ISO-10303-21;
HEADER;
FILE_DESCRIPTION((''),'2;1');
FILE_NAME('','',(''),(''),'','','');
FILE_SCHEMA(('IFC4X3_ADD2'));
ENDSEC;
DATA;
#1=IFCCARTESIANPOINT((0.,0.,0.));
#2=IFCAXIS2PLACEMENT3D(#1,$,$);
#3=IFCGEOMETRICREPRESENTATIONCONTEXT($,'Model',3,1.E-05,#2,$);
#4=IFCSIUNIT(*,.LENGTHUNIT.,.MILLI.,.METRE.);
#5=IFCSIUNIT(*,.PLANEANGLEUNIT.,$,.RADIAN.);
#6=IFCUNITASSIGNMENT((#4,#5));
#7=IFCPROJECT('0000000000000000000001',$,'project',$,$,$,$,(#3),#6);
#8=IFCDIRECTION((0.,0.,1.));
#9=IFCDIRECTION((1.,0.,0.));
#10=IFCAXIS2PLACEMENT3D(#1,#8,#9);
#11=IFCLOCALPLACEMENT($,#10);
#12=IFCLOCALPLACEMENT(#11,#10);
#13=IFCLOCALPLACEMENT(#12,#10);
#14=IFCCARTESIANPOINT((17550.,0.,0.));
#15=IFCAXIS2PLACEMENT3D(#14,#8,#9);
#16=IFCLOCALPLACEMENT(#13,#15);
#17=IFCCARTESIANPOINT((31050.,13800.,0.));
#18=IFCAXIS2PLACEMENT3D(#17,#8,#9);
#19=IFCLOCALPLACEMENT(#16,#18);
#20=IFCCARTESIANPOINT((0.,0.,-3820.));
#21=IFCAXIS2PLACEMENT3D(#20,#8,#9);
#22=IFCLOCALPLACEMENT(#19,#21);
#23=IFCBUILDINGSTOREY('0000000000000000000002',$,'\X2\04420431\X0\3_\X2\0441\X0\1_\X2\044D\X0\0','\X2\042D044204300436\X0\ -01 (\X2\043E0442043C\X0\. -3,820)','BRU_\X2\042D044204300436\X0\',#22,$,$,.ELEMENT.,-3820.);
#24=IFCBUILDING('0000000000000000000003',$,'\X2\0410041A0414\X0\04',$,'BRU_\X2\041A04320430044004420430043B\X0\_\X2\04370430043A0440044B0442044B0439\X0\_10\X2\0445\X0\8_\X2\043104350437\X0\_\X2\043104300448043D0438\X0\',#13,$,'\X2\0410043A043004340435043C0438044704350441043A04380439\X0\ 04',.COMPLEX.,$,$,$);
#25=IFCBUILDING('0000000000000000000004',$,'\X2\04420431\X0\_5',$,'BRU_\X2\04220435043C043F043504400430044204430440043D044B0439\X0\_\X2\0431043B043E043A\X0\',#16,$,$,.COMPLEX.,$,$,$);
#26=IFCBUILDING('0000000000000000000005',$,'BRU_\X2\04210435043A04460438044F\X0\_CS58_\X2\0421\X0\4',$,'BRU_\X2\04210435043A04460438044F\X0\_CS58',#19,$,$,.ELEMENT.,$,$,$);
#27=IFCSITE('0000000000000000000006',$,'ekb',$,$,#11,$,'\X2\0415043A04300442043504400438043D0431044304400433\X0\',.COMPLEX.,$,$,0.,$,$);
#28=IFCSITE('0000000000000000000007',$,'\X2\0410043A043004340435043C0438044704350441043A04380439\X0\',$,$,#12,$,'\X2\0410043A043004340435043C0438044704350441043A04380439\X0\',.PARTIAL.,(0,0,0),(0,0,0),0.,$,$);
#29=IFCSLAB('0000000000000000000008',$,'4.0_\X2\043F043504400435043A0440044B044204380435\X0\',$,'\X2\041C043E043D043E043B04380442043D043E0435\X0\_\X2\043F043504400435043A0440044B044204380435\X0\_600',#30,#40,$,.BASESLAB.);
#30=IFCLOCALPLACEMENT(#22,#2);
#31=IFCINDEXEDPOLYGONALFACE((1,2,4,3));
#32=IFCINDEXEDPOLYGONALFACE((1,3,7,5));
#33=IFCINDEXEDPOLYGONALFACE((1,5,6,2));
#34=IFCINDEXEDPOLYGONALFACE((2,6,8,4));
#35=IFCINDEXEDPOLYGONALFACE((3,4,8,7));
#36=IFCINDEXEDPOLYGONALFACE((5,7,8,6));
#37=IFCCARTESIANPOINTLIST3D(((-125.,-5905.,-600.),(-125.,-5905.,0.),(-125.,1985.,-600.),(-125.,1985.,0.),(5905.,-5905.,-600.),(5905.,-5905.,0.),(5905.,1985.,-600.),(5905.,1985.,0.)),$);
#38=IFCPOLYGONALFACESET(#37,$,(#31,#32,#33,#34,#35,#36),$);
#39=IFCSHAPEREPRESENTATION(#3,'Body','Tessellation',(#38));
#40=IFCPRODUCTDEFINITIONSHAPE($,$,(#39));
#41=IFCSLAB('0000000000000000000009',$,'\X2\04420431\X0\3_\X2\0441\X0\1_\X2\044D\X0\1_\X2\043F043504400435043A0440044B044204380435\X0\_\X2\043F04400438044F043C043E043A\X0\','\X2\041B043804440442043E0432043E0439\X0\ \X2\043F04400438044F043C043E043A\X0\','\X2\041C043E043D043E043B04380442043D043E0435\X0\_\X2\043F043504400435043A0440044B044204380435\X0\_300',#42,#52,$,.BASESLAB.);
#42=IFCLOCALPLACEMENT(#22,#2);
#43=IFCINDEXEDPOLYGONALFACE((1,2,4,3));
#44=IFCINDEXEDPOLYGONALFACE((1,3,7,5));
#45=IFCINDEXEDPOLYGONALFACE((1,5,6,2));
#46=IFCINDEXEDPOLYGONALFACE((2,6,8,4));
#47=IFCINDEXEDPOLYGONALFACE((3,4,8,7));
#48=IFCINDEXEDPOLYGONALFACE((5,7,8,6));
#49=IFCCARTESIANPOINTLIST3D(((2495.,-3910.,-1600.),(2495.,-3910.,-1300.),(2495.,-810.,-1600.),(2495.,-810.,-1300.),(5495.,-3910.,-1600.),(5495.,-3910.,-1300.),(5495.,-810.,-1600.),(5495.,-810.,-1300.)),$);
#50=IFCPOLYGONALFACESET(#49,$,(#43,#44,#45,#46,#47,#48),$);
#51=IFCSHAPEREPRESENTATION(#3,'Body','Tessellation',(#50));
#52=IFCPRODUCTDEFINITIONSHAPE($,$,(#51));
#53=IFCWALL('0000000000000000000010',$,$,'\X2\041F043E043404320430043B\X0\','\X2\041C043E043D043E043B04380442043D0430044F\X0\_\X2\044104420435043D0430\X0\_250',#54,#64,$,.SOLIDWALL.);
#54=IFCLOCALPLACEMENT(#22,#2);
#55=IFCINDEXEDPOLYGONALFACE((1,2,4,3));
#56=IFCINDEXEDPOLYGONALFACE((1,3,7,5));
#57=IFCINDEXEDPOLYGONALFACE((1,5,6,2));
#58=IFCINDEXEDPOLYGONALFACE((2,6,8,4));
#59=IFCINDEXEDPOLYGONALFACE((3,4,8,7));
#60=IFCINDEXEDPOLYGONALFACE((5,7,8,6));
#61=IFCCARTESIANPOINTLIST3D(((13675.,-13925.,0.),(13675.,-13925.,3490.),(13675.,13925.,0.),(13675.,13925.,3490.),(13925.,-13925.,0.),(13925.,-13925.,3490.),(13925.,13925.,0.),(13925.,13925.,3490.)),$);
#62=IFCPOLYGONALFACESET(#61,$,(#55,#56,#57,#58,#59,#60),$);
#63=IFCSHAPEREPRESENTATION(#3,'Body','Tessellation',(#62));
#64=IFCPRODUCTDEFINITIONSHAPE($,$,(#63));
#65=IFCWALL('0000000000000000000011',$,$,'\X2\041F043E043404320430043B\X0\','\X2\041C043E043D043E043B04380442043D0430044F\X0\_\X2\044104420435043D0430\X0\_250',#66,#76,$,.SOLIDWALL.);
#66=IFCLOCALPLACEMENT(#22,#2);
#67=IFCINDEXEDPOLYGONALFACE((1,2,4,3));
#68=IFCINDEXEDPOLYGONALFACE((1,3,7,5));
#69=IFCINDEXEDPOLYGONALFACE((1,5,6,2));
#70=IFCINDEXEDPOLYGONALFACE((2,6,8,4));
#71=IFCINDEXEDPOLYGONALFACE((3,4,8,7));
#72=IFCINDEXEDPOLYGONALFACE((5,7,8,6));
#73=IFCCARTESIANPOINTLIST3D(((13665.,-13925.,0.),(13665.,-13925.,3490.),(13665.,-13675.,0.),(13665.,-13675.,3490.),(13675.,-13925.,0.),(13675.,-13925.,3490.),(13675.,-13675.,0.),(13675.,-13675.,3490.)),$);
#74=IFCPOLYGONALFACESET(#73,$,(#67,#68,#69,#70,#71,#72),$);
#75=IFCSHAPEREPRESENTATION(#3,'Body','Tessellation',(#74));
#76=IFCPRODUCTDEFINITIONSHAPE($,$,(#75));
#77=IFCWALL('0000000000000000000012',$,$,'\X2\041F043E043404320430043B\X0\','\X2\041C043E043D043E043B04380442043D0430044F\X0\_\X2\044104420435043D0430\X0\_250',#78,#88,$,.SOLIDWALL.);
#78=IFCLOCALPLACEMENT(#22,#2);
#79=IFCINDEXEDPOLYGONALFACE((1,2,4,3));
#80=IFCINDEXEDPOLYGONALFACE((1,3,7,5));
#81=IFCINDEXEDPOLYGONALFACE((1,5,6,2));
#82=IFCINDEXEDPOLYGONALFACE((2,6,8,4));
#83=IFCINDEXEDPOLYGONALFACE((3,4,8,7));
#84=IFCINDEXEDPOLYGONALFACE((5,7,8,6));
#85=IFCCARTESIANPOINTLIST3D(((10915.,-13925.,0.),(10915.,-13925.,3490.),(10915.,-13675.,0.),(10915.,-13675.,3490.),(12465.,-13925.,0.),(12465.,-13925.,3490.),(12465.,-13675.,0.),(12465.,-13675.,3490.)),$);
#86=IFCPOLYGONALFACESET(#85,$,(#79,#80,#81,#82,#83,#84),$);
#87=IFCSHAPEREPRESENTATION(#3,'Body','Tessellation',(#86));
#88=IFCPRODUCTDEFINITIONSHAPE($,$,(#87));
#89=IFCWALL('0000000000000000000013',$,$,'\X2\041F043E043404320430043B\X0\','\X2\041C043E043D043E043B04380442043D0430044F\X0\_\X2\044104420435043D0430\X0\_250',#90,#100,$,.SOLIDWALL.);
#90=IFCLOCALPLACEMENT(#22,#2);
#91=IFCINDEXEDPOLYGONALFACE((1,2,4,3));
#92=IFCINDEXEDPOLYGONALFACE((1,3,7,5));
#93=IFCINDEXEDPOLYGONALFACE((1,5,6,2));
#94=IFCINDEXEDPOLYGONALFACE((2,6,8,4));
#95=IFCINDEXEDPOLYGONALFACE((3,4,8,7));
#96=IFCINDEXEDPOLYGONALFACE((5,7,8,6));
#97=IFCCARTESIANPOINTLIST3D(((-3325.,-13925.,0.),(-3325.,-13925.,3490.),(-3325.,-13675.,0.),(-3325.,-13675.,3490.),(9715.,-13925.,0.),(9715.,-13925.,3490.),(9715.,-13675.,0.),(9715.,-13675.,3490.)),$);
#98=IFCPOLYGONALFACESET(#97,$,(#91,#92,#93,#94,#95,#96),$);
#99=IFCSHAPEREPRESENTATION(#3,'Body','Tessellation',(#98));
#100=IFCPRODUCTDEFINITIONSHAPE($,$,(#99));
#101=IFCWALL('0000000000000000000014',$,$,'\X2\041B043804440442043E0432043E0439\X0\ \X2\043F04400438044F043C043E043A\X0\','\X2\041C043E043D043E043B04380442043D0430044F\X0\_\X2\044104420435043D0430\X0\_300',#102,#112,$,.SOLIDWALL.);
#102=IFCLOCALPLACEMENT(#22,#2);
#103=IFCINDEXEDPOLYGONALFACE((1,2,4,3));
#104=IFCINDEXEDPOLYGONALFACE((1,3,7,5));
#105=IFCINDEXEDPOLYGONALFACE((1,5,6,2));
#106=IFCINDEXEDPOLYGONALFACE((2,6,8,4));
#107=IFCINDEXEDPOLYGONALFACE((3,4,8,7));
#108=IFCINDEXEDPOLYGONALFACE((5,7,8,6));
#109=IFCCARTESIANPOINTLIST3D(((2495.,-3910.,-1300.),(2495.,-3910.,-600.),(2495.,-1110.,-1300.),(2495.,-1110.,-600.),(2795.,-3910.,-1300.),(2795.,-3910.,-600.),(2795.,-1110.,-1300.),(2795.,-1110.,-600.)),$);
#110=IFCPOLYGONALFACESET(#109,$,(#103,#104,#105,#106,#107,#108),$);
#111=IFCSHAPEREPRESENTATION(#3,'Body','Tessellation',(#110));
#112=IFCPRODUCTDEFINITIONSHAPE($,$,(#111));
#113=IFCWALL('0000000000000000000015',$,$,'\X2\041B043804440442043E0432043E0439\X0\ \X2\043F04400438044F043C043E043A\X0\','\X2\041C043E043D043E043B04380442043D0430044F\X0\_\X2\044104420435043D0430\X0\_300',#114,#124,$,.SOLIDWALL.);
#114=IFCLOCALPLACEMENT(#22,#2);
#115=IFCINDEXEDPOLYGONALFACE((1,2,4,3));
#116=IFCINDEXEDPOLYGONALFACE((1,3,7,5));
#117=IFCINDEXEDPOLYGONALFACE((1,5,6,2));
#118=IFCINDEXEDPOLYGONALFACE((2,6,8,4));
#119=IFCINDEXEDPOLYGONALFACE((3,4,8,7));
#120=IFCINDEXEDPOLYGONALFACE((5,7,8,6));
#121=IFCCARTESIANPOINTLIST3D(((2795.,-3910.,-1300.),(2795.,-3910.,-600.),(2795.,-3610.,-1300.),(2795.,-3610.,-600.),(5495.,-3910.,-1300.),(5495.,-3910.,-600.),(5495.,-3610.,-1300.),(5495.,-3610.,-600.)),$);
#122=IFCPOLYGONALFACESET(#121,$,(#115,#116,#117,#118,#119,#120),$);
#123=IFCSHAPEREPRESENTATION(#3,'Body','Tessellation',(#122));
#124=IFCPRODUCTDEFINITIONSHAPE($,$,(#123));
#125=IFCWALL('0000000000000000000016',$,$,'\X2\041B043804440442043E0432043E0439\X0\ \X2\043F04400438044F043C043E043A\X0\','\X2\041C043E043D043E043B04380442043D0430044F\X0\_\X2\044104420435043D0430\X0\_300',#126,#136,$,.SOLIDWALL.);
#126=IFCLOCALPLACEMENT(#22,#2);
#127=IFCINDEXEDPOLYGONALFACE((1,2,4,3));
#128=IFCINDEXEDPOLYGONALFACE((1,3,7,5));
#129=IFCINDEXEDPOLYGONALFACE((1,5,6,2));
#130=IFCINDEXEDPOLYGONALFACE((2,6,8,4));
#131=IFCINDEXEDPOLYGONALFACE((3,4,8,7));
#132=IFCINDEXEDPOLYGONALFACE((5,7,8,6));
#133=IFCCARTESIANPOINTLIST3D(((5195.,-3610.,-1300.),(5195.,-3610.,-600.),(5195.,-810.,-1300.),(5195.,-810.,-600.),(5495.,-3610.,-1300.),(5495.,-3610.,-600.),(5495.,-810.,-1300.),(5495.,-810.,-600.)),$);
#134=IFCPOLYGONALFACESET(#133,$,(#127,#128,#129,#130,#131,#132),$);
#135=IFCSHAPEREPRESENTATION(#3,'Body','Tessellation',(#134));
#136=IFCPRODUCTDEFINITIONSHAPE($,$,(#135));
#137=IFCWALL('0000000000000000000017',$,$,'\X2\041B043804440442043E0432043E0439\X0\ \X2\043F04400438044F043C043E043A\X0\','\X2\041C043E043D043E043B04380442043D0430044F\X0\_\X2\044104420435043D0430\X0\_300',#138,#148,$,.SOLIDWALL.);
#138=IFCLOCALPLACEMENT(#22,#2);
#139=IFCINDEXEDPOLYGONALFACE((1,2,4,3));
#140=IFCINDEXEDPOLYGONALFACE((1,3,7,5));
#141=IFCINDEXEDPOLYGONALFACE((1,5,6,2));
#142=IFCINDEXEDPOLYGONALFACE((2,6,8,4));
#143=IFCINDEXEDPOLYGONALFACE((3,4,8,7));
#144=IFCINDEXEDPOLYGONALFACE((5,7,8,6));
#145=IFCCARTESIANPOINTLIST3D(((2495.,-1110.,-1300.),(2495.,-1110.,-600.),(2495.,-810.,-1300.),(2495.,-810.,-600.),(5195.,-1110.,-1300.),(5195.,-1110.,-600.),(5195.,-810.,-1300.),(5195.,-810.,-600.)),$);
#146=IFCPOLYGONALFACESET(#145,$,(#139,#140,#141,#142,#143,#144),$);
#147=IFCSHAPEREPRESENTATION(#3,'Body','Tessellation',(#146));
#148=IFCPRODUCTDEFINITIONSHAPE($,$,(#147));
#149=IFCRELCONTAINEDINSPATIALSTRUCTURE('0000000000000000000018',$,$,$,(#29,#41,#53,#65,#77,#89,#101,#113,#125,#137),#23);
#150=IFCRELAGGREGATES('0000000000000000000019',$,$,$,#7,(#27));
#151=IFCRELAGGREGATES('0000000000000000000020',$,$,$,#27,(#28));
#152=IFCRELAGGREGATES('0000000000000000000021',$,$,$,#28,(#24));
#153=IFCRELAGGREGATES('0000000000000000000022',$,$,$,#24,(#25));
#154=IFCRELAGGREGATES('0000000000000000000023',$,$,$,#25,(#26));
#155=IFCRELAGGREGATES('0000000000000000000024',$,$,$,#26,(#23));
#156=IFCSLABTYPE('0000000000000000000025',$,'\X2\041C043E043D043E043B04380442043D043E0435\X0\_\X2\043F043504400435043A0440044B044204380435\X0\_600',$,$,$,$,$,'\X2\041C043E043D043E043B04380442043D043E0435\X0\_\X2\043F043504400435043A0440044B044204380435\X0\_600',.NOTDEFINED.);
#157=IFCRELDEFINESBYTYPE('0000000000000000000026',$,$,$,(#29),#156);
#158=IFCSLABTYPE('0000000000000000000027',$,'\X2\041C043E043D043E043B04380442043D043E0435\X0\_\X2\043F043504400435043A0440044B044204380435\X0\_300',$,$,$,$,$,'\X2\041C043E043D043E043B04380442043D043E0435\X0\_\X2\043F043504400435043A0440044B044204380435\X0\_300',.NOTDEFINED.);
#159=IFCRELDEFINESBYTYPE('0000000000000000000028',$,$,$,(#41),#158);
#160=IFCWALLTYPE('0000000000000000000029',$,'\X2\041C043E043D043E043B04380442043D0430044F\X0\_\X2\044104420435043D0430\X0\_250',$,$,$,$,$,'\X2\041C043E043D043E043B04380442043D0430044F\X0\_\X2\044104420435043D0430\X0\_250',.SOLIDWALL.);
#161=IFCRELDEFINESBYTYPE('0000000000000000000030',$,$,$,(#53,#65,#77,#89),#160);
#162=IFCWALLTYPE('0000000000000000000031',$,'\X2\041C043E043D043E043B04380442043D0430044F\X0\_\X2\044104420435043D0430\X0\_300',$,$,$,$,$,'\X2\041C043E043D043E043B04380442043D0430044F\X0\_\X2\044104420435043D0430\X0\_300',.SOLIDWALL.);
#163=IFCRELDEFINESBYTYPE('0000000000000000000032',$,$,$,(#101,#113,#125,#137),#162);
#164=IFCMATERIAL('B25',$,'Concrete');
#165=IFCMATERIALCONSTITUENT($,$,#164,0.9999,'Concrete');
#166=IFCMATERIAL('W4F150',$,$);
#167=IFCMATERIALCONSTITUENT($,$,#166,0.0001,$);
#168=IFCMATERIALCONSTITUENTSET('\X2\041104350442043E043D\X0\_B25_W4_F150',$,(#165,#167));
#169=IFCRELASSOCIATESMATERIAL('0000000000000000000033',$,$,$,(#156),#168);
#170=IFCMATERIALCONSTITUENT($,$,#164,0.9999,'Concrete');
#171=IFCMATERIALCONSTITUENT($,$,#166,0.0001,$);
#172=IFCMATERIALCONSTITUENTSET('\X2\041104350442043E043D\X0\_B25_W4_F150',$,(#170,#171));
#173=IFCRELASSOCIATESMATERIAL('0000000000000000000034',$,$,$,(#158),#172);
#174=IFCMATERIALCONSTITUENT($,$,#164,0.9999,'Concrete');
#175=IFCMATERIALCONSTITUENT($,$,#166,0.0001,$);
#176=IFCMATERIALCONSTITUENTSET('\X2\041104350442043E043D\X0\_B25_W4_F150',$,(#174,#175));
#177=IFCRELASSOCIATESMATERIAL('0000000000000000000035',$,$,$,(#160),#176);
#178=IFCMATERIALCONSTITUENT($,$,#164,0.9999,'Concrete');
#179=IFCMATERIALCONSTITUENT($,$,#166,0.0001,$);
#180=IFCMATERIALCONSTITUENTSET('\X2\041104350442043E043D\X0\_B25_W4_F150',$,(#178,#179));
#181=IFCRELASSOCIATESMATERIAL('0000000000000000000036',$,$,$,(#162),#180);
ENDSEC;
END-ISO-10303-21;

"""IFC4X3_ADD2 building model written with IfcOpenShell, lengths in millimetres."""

from ifc_helpers import new_model, si_unit, frame, origin, origin_with_axes, origin_2d_with_axis, place, context, project, spatial, polyline, rectangle, outline, extrude, material, constituent, constituent_set, type_object, element, save


model = new_model("IFC4X3_ADD2")

# Units and contexts
model_context = context("Model", 3, precision=1e-05, world=origin())
ifc_project = project(units=[si_unit("LENGTHUNIT", "METRE", prefix="MILLI"), si_unit("PLANEANGLEUNIT", "RADIAN")], contexts=[model_context])

# Sites, buildings, storey
site_1_placement = place(None, origin_with_axes())
site_1 = spatial("IfcSite", under=ifc_project, at=site_1_placement, Name="ekb", LongName="Екатеринбург", CompositionType="COMPLEX", RefElevation=0.0)
site_2_placement = place(site_1_placement, origin_with_axes())
site_2 = spatial("IfcSite", under=site_1, at=site_2_placement, Name="Академический", LongName="Академический", CompositionType="PARTIAL", RefLatitude=(0, 0, 0), RefLongitude=(0, 0, 0), RefElevation=0.0)
building_1_placement = place(site_2_placement, origin_with_axes())
building_1 = spatial("IfcBuilding", under=site_2, at=building_1_placement, Name="АКД04", ObjectType="BRU_Квартал_закрытый_10х8_без_башни", LongName="Академический 04", CompositionType="COMPLEX")
building_2_placement = place(building_1_placement, frame((17550.0, 0.0, 0.0), z_axis=(0.0, 0.0, 1.0), x_axis=(1.0, 0.0, 0.0)))
building_2 = spatial("IfcBuilding", under=building_1, at=building_2_placement, Name="тб_5", ObjectType="BRU_Температурный_блок", CompositionType="COMPLEX")
building_3_placement = place(building_2_placement, frame((31050.0, 13800.0, 0.0), z_axis=(0.0, 0.0, 1.0), x_axis=(1.0, 0.0, 0.0)))
building_3 = spatial("IfcBuilding", under=building_2, at=building_3_placement, Name="BRU_Секция_CS58_С4", ObjectType="BRU_Секция_CS58", CompositionType="ELEMENT")
storey_placement = place(building_3_placement, frame((0.0, 0.0, -3820.0), z_axis=(0.0, 0.0, 1.0), x_axis=(1.0, 0.0, 0.0)))
storey = spatial("IfcBuildingStorey", under=building_3, at=storey_placement, Name="тб3_с1_э0", Description="Этаж -01 (отм. -3,820)", ObjectType="BRU_Этаж", CompositionType="ELEMENT", Elevation=-3820.0)

# Shared definitions
ifc_material_1 = material(Name="B25", Category="Concrete")
ifc_material_2 = material(Name="W4F150")

# Slabs
ifc_constituent_1 = constituent(ifc_material_1, Category="Concrete", fraction=0.9999)
ifc_constituent_2 = constituent(ifc_material_2, fraction=0.0001)
ifc_constituent_set_1 = constituent_set(constituents=[ifc_constituent_1, ifc_constituent_2], Name="Бетон_B25_W4_F150")
slab_type_1 = type_object("IfcSlabType", Name="Монолитное_перекрытие_600", ElementType="Монолитное_перекрытие_600", PredefinedType="NOTDEFINED", material=ifc_constituent_set_1)
slab_1_placement = place(storey_placement, frame((0.0, 0.0, -600.0), z_axis=(0.0, 0.0, 1.0), x_axis=(1.0, 0.0, 0.0)))
element("IfcSlab", 1, at=slab_1_placement, inside=storey, type_object=slab_type_1, Name="4.0_перекрытие", ObjectType="Монолитное_перекрытие_600", PredefinedType="BASESLAB", context=model_context, shape_type="SweptSolid", body=[
    extrude(outline(polyline([(-125.0, -5905.0), (5905.0, -5905.0), (5905.0, 1985.0), (-125.0, 1985.0), (-125.0, -5905.0)])), origin_with_axes(), (0.0, 0.0, 1.0), 600.0),
])
ifc_constituent_3 = constituent(ifc_material_1, Category="Concrete", fraction=0.9999)
ifc_constituent_4 = constituent(ifc_material_2, fraction=0.0001)
ifc_constituent_set_2 = constituent_set(constituents=[ifc_constituent_3, ifc_constituent_4], Name="Бетон_B25_W4_F150")
slab_type_2 = type_object("IfcSlabType", Name="Монолитное_перекрытие_300", ElementType="Монолитное_перекрытие_300", PredefinedType="NOTDEFINED", material=ifc_constituent_set_2)
slab_2_placement = place(storey_placement, frame((3995.0, -2360.0, -1600.0), z_axis=(0.0, 0.0, 1.0), x_axis=(0.0, -1.0, 0.0)))
element("IfcSlab", 2, at=slab_2_placement, inside=storey, type_object=slab_type_2, Name="тб3_с1_э1_перекрытие_приямок", Description="Лифтовой приямок", ObjectType="Монолитное_перекрытие_300", PredefinedType="BASESLAB", context=model_context, shape_type="SweptSolid", body=[
    extrude(outline(polyline([(-1550.0, -1500.0), (-1550.0, 1500.0), (1550.0, 1500.0), (1550.0, -1500.0), (-1550.0, -1500.0)])), origin_with_axes(), (0.0, 0.0, 1.0), 300.0),
])

# Walls
ifc_constituent_5 = constituent(ifc_material_1, Category="Concrete", fraction=0.9999)
ifc_constituent_6 = constituent(ifc_material_2, fraction=0.0001)
ifc_constituent_set_3 = constituent_set(constituents=[ifc_constituent_5, ifc_constituent_6], Name="Бетон_B25_W4_F150")
wall_type_1 = type_object("IfcWallType", Name="Монолитная_стена_250", ElementType="Монолитная_стена_250", PredefinedType="SOLIDWALL", material=ifc_constituent_set_3)
wall_1_placement = place(storey_placement, frame((13800.0, 13925.0, 0.0), z_axis=(0.0, 0.0, 1.0), x_axis=(0.0, -1.0, 0.0)))
element("IfcWall", 3, at=wall_1_placement, inside=storey, type_object=wall_type_1, Description="Подвал", ObjectType="Монолитная_стена_250", PredefinedType="SOLIDWALL", context=model_context, shape_type="SweptSolid", body=[
    extrude(rectangle(XDim=27850.0, YDim=250.0, at=origin_2d_with_axis()), frame((13925.0, 0.0, 0.0), z_axis=(0.0, 0.0, 1.0), x_axis=(1.0, 0.0, 0.0)), (0.0, 0.0, 1.0), 3490.0),
])
wall_2_placement = place(storey_placement, frame((13675.0, -13800.0, 0.0), z_axis=(0.0, 0.0, 1.0), x_axis=(-1.0, 0.0, 0.0)))
element("IfcWall", 4, at=wall_2_placement, inside=storey, type_object=wall_type_1, Description="Подвал", ObjectType="Монолитная_стена_250", PredefinedType="SOLIDWALL", context=model_context, shape_type="SweptSolid", body=[
    extrude(rectangle(XDim=10.0, YDim=250.0, at=origin_2d_with_axis()), frame((5.0, 0.0, 0.0), z_axis=(0.0, 0.0, 1.0), x_axis=(1.0, 0.0, 0.0)), (0.0, 0.0, 1.0), 3490.0),
])
wall_3_placement = place(storey_placement, frame((12465.0, -13800.0, 0.0), z_axis=(0.0, 0.0, 1.0), x_axis=(-1.0, 0.0, 0.0)))
element("IfcWall", 5, at=wall_3_placement, inside=storey, type_object=wall_type_1, Description="Подвал", ObjectType="Монолитная_стена_250", PredefinedType="SOLIDWALL", context=model_context, shape_type="SweptSolid", body=[
    extrude(rectangle(XDim=1550.0, YDim=250.0, at=origin_2d_with_axis()), frame((775.0, 0.0, 0.0), z_axis=(0.0, 0.0, 1.0), x_axis=(1.0, 0.0, 0.0)), (0.0, 0.0, 1.0), 3490.0),
])
wall_4_placement = place(storey_placement, frame((9715.0, -13800.0, 0.0), z_axis=(0.0, 0.0, 1.0), x_axis=(-1.0, 0.0, 0.0)))
element("IfcWall", 6, at=wall_4_placement, inside=storey, type_object=wall_type_1, Description="Подвал", ObjectType="Монолитная_стена_250", PredefinedType="SOLIDWALL", context=model_context, shape_type="SweptSolid", body=[
    extrude(rectangle(XDim=13040.0, YDim=250.0, at=origin_2d_with_axis()), frame((6520.0, 0.0, 0.0), z_axis=(0.0, 0.0, 1.0), x_axis=(1.0, 0.0, 0.0)), (0.0, 0.0, 1.0), 3490.0),
])
ifc_constituent_7 = constituent(ifc_material_1, Category="Concrete", fraction=0.9999)
ifc_constituent_8 = constituent(ifc_material_2, fraction=0.0001)
ifc_constituent_set_4 = constituent_set(constituents=[ifc_constituent_7, ifc_constituent_8], Name="Бетон_B25_W4_F150")
wall_type_2 = type_object("IfcWallType", Name="Монолитная_стена_300", ElementType="Монолитная_стена_300", PredefinedType="SOLIDWALL", material=ifc_constituent_set_4)
wall_5_placement = place(storey_placement, frame((2645.0, -1110.0, -1300.0), z_axis=(0.0, 0.0, 1.0), x_axis=(0.0, -1.0, 0.0)))
element("IfcWall", 7, at=wall_5_placement, inside=storey, type_object=wall_type_2, Description="Лифтовой приямок", ObjectType="Монолитная_стена_300", PredefinedType="SOLIDWALL", context=model_context, shape_type="SweptSolid", body=[
    extrude(rectangle(XDim=2800.0, YDim=300.0, at=origin_2d_with_axis()), frame((1400.0, 0.0, 0.0), z_axis=(0.0, 0.0, 1.0), x_axis=(1.0, 0.0, 0.0)), (0.0, 0.0, 1.0), 700.0),
])
wall_6_placement = place(storey_placement, frame((2795.0, -3760.0, -1300.0), z_axis=(0.0, 0.0, 1.0), x_axis=(1.0, 0.0, 0.0)))
element("IfcWall", 8, at=wall_6_placement, inside=storey, type_object=wall_type_2, Description="Лифтовой приямок", ObjectType="Монолитная_стена_300", PredefinedType="SOLIDWALL", context=model_context, shape_type="SweptSolid", body=[
    extrude(rectangle(XDim=2700.0, YDim=300.0, at=origin_2d_with_axis()), frame((1350.0, 0.0, 0.0), z_axis=(0.0, 0.0, 1.0), x_axis=(1.0, 0.0, 0.0)), (0.0, 0.0, 1.0), 700.0),
])
wall_7_placement = place(storey_placement, frame((5345.0, -3610.0, -1300.0), z_axis=(0.0, 0.0, 1.0), x_axis=(0.0, 1.0, 0.0)))
element("IfcWall", 9, at=wall_7_placement, inside=storey, type_object=wall_type_2, Description="Лифтовой приямок", ObjectType="Монолитная_стена_300", PredefinedType="SOLIDWALL", context=model_context, shape_type="SweptSolid", body=[
    extrude(rectangle(XDim=2800.0, YDim=300.0, at=origin_2d_with_axis()), frame((1400.0, 0.0, 0.0), z_axis=(0.0, 0.0, 1.0), x_axis=(1.0, 0.0, 0.0)), (0.0, 0.0, 1.0), 700.0),
])
wall_8_placement = place(storey_placement, frame((5195.0, -960.0, -1300.0), z_axis=(0.0, 0.0, 1.0), x_axis=(-1.0, 0.0, 0.0)))
element("IfcWall", 10, at=wall_8_placement, inside=storey, type_object=wall_type_2, Description="Лифтовой приямок", ObjectType="Монолитная_стена_300", PredefinedType="SOLIDWALL", context=model_context, shape_type="SweptSolid", body=[
    extrude(rectangle(XDim=2700.0, YDim=300.0, at=origin_2d_with_axis()), frame((1350.0, 0.0, 0.0), z_axis=(0.0, 0.0, 1.0), x_axis=(1.0, 0.0, 0.0)), (0.0, 0.0, 1.0), 700.0),
])

save(model, "model.ifc")
